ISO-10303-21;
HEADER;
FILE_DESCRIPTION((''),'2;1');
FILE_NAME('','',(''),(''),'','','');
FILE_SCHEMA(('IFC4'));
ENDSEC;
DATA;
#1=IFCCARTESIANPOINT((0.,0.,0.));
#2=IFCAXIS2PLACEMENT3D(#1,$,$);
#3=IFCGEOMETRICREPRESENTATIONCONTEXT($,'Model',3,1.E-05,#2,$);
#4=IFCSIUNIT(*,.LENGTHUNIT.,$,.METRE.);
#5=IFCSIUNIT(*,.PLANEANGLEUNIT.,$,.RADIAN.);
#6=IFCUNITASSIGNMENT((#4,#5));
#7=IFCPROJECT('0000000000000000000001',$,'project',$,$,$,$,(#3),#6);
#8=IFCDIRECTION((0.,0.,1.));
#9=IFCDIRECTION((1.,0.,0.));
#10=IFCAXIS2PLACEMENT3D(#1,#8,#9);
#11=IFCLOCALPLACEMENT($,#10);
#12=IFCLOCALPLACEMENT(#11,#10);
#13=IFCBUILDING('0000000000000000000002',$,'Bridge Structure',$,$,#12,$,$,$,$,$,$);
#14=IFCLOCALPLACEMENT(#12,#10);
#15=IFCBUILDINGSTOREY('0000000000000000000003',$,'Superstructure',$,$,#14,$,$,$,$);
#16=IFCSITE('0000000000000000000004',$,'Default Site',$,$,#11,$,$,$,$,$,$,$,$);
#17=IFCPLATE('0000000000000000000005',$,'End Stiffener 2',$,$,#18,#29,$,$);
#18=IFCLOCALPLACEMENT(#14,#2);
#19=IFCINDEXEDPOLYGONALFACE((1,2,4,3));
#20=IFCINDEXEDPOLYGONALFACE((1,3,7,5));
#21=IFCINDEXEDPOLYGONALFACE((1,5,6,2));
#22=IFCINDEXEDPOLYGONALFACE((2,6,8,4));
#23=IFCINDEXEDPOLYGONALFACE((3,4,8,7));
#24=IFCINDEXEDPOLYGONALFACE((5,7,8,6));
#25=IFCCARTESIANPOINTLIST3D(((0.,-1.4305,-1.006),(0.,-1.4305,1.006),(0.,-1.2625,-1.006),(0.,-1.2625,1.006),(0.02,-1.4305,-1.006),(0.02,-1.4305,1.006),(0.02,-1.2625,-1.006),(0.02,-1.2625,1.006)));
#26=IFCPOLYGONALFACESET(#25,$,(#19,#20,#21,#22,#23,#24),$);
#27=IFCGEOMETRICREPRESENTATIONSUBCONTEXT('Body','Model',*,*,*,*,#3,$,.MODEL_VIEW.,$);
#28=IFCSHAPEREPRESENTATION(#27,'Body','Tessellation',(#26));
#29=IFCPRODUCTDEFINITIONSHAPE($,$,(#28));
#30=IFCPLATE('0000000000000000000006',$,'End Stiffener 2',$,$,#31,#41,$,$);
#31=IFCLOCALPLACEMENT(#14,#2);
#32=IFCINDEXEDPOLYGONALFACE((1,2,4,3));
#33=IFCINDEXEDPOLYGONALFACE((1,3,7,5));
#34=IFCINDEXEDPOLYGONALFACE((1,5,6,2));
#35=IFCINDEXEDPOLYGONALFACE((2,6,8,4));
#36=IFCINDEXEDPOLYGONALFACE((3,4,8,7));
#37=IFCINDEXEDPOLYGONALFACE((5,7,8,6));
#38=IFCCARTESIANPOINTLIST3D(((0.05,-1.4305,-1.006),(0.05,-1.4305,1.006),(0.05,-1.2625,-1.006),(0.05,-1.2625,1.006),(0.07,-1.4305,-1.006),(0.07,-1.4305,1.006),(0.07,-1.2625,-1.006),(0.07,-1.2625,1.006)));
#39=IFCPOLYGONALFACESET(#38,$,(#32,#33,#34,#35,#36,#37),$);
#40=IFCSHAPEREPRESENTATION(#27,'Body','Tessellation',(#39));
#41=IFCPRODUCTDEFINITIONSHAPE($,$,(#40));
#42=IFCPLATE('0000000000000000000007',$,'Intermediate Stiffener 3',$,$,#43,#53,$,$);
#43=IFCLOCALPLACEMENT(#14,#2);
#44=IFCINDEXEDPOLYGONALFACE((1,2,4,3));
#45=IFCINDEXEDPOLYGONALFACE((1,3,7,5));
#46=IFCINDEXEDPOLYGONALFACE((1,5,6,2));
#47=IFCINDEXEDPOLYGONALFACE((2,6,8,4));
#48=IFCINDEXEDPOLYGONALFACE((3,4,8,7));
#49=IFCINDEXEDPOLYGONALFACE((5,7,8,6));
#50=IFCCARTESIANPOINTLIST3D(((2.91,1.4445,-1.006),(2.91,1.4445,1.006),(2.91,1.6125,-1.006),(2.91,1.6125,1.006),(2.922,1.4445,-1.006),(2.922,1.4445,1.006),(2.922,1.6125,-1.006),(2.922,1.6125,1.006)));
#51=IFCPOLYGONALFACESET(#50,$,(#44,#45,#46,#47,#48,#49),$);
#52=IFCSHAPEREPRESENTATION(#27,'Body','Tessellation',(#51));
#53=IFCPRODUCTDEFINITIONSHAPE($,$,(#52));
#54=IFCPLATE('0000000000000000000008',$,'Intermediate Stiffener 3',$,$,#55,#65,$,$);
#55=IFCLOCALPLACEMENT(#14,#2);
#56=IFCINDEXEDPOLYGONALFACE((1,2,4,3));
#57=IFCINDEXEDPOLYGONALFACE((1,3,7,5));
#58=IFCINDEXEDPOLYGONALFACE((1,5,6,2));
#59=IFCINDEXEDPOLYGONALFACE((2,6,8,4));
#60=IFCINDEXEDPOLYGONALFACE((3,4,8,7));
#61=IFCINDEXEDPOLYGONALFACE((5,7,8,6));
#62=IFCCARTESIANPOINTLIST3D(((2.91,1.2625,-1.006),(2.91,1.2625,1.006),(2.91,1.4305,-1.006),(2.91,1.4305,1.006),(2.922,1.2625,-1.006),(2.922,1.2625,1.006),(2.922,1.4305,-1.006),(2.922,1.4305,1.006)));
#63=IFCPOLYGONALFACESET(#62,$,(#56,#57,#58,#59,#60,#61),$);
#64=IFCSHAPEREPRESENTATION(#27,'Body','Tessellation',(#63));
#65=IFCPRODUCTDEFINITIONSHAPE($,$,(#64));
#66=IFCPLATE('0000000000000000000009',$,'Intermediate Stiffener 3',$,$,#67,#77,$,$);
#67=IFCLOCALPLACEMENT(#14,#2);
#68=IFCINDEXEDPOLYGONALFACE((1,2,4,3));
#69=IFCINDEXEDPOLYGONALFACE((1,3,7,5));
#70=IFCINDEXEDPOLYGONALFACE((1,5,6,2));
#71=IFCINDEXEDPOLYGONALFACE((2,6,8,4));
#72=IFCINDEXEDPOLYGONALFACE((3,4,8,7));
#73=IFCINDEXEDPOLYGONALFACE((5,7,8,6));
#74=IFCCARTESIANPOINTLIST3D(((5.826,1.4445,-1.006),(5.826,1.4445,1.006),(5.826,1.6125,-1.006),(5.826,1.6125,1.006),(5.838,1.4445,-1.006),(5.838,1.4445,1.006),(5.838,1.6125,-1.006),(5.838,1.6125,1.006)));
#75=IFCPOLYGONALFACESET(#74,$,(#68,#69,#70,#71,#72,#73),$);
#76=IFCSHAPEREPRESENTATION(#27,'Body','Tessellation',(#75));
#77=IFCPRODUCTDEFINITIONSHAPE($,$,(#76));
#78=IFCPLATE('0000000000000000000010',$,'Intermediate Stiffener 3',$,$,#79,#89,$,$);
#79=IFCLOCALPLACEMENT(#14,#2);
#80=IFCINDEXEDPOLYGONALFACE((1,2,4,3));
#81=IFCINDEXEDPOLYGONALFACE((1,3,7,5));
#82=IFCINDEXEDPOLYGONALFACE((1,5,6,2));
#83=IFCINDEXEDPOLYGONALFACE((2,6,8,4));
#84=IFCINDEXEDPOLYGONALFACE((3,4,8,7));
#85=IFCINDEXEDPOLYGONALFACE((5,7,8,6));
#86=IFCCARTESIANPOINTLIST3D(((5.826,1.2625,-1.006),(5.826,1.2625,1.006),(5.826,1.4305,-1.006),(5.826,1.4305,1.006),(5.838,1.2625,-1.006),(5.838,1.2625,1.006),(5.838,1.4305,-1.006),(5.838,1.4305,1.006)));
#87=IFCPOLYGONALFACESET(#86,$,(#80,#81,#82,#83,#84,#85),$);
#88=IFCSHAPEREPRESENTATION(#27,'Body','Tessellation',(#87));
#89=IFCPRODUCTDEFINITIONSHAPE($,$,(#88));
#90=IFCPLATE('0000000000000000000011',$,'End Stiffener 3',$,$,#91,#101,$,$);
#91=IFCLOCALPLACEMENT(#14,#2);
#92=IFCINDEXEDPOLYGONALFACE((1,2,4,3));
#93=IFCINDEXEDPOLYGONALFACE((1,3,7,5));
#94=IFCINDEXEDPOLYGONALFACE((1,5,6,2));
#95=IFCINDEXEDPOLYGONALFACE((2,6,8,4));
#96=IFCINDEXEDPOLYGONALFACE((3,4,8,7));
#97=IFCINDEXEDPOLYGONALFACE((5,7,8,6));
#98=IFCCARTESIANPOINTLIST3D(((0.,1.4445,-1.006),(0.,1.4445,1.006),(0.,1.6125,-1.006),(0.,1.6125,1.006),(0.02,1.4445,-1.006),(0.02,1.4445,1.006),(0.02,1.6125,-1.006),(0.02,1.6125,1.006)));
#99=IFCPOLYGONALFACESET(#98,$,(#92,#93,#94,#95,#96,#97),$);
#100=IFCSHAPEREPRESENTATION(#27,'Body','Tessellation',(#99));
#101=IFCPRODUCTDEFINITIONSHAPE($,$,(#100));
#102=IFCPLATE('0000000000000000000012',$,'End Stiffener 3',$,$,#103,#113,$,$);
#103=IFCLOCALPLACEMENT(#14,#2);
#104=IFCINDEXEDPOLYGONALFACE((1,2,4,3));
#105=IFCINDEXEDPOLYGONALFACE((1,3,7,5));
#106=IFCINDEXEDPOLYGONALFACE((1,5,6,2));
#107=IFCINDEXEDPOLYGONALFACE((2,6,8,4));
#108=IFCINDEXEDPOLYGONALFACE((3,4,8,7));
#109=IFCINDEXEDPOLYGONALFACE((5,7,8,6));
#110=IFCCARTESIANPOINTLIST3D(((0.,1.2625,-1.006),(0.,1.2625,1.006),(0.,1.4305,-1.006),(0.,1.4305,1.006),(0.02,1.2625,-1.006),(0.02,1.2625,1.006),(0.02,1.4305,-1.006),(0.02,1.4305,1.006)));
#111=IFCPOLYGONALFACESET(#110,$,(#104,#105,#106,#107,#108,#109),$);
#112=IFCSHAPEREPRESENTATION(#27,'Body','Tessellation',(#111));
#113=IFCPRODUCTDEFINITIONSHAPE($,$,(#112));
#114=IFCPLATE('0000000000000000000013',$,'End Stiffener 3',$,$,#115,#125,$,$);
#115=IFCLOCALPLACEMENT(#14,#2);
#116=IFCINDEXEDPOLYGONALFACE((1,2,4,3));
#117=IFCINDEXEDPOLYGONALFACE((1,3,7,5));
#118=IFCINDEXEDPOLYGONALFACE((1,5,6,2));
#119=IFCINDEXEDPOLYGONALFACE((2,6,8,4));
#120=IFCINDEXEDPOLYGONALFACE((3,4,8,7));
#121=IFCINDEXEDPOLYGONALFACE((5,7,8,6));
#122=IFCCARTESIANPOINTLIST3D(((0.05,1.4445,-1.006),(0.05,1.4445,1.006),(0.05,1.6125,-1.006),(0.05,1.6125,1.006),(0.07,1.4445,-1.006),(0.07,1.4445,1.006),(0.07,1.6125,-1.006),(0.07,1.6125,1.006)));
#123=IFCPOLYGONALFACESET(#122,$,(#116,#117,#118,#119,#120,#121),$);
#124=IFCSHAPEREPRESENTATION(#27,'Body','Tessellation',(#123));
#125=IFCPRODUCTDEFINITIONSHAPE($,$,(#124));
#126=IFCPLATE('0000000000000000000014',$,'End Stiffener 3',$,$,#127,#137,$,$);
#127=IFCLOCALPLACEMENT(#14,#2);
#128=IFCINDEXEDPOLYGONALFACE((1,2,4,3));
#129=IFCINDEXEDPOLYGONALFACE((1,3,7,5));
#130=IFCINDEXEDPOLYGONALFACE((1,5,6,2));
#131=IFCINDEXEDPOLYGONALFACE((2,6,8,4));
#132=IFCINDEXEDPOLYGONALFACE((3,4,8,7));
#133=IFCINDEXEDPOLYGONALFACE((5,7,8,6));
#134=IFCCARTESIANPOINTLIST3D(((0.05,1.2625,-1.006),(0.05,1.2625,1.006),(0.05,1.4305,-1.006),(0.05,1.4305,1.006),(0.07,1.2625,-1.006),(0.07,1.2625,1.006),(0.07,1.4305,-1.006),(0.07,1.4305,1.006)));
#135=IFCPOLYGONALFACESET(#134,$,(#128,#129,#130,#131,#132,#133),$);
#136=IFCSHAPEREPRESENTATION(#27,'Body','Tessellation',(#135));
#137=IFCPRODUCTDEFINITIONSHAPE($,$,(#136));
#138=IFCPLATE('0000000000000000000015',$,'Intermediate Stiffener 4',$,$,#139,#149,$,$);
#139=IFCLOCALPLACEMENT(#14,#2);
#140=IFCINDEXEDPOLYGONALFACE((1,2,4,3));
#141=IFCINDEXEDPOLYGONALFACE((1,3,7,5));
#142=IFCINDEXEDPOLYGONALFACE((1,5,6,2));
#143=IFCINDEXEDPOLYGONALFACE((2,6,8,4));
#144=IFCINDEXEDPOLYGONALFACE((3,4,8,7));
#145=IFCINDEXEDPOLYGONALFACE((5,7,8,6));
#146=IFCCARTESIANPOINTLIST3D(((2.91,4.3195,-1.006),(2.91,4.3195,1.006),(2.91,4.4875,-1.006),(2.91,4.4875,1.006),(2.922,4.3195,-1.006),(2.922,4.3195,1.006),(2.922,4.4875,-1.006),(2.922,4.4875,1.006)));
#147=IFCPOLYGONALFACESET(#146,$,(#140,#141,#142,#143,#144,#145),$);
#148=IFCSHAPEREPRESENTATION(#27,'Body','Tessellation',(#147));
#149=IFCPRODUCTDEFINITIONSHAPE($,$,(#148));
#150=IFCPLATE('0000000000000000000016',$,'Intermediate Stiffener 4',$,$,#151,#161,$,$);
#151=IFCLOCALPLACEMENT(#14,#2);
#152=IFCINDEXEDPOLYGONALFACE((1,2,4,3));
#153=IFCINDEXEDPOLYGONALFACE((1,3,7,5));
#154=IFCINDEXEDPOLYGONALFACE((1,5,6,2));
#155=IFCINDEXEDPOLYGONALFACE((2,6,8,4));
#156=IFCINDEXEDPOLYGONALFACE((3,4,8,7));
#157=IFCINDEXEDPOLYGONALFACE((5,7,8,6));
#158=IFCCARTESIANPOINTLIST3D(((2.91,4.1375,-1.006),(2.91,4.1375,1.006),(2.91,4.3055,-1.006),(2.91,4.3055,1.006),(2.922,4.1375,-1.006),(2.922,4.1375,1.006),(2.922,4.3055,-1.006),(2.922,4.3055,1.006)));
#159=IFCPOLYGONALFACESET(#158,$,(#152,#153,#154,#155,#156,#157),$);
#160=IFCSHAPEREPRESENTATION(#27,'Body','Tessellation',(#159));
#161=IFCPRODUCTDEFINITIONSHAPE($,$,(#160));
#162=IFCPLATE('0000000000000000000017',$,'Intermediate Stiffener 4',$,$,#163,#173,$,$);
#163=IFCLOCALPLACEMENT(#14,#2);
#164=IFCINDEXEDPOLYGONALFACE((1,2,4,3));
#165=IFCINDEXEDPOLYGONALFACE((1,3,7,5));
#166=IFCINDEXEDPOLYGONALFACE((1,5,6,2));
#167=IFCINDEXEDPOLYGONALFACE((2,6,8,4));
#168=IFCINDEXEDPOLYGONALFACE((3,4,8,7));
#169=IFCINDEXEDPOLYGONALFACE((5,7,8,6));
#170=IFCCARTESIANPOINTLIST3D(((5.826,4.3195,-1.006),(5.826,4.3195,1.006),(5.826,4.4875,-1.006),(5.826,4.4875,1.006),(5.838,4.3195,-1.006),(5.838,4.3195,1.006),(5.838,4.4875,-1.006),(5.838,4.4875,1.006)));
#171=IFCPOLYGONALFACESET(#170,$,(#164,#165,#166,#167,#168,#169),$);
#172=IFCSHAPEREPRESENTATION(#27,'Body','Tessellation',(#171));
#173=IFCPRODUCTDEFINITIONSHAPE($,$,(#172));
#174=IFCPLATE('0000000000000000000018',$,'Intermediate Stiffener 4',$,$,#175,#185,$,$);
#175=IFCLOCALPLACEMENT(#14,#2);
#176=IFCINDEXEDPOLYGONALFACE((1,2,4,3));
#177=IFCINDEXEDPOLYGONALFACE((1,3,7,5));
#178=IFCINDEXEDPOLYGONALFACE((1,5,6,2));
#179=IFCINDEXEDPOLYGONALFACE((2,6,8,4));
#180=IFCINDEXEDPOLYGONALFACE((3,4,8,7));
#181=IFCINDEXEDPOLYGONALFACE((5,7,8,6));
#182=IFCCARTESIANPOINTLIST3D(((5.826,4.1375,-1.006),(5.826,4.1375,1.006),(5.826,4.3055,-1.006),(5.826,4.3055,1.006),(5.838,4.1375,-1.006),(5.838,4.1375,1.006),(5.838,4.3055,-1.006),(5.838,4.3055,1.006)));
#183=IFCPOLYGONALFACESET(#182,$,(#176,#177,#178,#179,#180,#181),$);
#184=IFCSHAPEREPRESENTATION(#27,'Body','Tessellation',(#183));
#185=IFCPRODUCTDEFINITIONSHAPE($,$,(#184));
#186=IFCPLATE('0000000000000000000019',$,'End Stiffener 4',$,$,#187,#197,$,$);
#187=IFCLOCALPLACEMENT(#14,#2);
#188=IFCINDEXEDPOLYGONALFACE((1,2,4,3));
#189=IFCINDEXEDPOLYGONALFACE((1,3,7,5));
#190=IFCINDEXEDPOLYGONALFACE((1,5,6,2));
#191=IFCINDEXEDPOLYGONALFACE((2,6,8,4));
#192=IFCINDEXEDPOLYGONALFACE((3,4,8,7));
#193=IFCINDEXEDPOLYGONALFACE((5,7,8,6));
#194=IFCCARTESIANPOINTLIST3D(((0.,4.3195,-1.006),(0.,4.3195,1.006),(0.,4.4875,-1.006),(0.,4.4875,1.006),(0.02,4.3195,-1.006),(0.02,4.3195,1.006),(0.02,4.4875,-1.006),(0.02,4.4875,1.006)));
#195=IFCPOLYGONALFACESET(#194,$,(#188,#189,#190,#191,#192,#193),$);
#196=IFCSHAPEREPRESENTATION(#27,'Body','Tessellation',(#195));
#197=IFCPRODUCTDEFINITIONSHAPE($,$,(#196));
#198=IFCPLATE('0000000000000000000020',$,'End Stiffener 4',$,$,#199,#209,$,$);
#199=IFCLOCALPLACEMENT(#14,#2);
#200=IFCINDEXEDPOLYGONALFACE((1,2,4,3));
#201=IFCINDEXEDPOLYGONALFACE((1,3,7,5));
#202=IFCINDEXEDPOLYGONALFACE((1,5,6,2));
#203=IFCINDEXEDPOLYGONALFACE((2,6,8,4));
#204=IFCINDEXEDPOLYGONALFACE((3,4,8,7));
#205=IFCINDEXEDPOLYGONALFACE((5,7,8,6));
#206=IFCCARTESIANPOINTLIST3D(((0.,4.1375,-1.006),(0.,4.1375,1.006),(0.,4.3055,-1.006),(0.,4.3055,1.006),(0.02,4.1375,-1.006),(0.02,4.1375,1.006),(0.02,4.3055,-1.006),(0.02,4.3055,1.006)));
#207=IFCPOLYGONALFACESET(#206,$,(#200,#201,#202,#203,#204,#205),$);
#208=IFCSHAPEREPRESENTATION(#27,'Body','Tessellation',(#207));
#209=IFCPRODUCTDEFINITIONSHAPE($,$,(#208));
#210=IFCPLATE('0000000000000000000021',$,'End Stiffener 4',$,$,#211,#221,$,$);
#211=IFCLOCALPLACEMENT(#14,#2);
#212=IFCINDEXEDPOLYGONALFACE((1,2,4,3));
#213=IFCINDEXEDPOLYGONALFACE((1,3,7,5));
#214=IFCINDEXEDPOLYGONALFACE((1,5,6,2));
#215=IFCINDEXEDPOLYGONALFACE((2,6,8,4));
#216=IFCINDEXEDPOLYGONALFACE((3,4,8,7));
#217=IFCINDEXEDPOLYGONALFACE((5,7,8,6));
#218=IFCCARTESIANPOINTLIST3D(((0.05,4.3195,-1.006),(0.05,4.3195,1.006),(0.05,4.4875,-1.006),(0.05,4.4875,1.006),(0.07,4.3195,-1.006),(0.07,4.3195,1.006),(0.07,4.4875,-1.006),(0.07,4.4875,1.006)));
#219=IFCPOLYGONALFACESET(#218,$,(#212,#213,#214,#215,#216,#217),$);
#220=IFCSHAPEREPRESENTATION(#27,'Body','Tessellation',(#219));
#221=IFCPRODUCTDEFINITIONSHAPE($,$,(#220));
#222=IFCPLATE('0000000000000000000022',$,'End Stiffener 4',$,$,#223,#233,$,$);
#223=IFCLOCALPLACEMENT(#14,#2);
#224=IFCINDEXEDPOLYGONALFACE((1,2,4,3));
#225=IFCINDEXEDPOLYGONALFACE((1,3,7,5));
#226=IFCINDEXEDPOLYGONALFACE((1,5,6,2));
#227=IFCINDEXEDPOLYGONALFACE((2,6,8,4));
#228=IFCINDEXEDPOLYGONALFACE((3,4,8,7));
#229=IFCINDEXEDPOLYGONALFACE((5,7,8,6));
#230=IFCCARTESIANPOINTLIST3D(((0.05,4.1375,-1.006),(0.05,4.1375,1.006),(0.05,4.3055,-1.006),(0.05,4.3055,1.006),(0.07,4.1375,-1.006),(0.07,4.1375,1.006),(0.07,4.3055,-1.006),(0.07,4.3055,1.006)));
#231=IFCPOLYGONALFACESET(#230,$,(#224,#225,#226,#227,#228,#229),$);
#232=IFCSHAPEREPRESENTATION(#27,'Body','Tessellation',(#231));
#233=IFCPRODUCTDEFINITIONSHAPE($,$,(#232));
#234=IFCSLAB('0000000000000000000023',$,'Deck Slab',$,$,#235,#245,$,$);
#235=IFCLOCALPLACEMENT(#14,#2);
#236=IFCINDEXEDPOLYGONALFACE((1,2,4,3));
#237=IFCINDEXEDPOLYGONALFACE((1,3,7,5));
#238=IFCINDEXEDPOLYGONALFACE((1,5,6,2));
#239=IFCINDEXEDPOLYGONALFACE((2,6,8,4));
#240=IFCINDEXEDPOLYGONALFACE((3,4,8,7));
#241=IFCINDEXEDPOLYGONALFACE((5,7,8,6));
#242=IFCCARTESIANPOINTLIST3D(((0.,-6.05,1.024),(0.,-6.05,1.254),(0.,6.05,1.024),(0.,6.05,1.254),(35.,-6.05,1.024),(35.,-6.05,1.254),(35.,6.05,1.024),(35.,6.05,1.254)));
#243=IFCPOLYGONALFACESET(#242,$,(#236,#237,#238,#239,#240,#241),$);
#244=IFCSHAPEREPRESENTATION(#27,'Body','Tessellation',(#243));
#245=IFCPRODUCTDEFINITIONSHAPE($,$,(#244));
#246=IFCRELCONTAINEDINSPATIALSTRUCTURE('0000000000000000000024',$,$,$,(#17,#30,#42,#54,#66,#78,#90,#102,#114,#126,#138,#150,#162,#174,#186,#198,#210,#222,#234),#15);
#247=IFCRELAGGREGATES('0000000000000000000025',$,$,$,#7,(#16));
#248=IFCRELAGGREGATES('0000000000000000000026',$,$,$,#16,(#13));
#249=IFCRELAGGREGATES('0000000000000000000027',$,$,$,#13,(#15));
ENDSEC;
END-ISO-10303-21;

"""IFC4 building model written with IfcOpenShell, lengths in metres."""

from ifc_helpers import new_model, si_unit, frame, origin, origin_with_axes, origin_2d_with_axis, place, context, subcontext, project, spatial, polyline, rectangle, outline, extrude, element, save


model = new_model("IFC4")

# Units and contexts
model_context = context("Model", 3, precision=1e-05, world=origin())
body_context = subcontext(model_context, "Body", "Model", "MODEL_VIEW")
ifc_project = project(units=[si_unit("LENGTHUNIT", "METRE"), si_unit("PLANEANGLEUNIT", "RADIAN")], contexts=[model_context])

# Site, building, storey
site_placement = place(None, origin_with_axes())
site = spatial("IfcSite", under=ifc_project, at=site_placement, Name="Default Site")
building_placement = place(site_placement, origin_with_axes())
building = spatial("IfcBuilding", under=site, at=building_placement, Name="Bridge Structure")
storey_placement = place(building_placement, origin_with_axes())
storey = spatial("IfcBuildingStorey", under=building, at=storey_placement, Name="Superstructure")

# Plates
for number, where, z_axis, x_axis, name in (
    (1, (0.01, -1.3465, -1.006), (0.0, 0.0, 1.0), (1.0, 0.0, 0.0), "End Stiffener 2"),
    (2, (0.06, -1.3465, -1.006), (0.0, 0.0, 1.0), (1.0, 0.0, 0.0), "End Stiffener 2"),
):
    element("IfcPlate", number, at=place(storey_placement, frame(where, z_axis=z_axis, x_axis=x_axis)), inside=storey, Name=name, context=body_context, shape_type="SweptSolid", body=[
        extrude(rectangle(XDim=0.02, YDim=0.168, at=origin_2d_with_axis()), origin_with_axes(), (0.0, 0.0, 1.0), 2.012),
    ])
for number, where, z_axis, x_axis, name in (
    (3, (2.916, 1.5285, -1.006), (0.0, 0.0, 1.0), (1.0, 0.0, 0.0), "Intermediate Stiffener 3"),
    (4, (2.916, 1.3465, -1.006), (0.0, 0.0, 1.0), (1.0, 0.0, 0.0), "Intermediate Stiffener 3"),
    (5, (5.832, 1.5285, -1.006), (0.0, 0.0, 1.0), (1.0, 0.0, 0.0), "Intermediate Stiffener 3"),
    (6, (5.832, 1.3465, -1.006), (0.0, 0.0, 1.0), (1.0, 0.0, 0.0), "Intermediate Stiffener 3"),
):
    element("IfcPlate", number, at=place(storey_placement, frame(where, z_axis=z_axis, x_axis=x_axis)), inside=storey, Name=name, context=body_context, shape_type="SweptSolid", body=[
        extrude(rectangle(XDim=0.012, YDim=0.168, at=origin_2d_with_axis()), origin_with_axes(), (0.0, 0.0, 1.0), 2.012),
    ])
for number, where, z_axis, x_axis, name in (
    (7, (0.01, 1.5285, -1.006), (0.0, 0.0, 1.0), (1.0, 0.0, 0.0), "End Stiffener 3"),
    (8, (0.01, 1.3465, -1.006), (0.0, 0.0, 1.0), (1.0, 0.0, 0.0), "End Stiffener 3"),
    (9, (0.06, 1.5285, -1.006), (0.0, 0.0, 1.0), (1.0, 0.0, 0.0), "End Stiffener 3"),
    (10, (0.06, 1.3465, -1.006), (0.0, 0.0, 1.0), (1.0, 0.0, 0.0), "End Stiffener 3"),
):
    element("IfcPlate", number, at=place(storey_placement, frame(where, z_axis=z_axis, x_axis=x_axis)), inside=storey, Name=name, context=body_context, shape_type="SweptSolid", body=[
        extrude(rectangle(XDim=0.02, YDim=0.168, at=origin_2d_with_axis()), origin_with_axes(), (0.0, 0.0, 1.0), 2.012),
    ])
for number, where, z_axis, x_axis, name in (
    (11, (2.916, 4.4035, -1.006), (0.0, 0.0, 1.0), (1.0, 0.0, 0.0), "Intermediate Stiffener 4"),
    (12, (2.916, 4.2215, -1.006), (0.0, 0.0, 1.0), (1.0, 0.0, 0.0), "Intermediate Stiffener 4"),
    (13, (5.832, 4.4035, -1.006), (0.0, 0.0, 1.0), (1.0, 0.0, 0.0), "Intermediate Stiffener 4"),
    (14, (5.832, 4.2215, -1.006), (0.0, 0.0, 1.0), (1.0, 0.0, 0.0), "Intermediate Stiffener 4"),
):
    element("IfcPlate", number, at=place(storey_placement, frame(where, z_axis=z_axis, x_axis=x_axis)), inside=storey, Name=name, context=body_context, shape_type="SweptSolid", body=[
        extrude(rectangle(XDim=0.012, YDim=0.168, at=origin_2d_with_axis()), origin_with_axes(), (0.0, 0.0, 1.0), 2.012),
    ])
for number, where, z_axis, x_axis, name in (
    (15, (0.01, 4.4035, -1.006), (0.0, 0.0, 1.0), (1.0, 0.0, 0.0), "End Stiffener 4"),
    (16, (0.01, 4.2215, -1.006), (0.0, 0.0, 1.0), (1.0, 0.0, 0.0), "End Stiffener 4"),
    (17, (0.06, 4.4035, -1.006), (0.0, 0.0, 1.0), (1.0, 0.0, 0.0), "End Stiffener 4"),
    (18, (0.06, 4.2215, -1.006), (0.0, 0.0, 1.0), (1.0, 0.0, 0.0), "End Stiffener 4"),
):
    element("IfcPlate", number, at=place(storey_placement, frame(where, z_axis=z_axis, x_axis=x_axis)), inside=storey, Name=name, context=body_context, shape_type="SweptSolid", body=[
        extrude(rectangle(XDim=0.02, YDim=0.168, at=origin_2d_with_axis()), origin_with_axes(), (0.0, 0.0, 1.0), 2.012),
    ])

# Slab
slab_placement = place(storey_placement, frame((0.0, 0.0, 1.024), z_axis=(0.0, 0.0, 1.0), x_axis=(1.0, 0.0, 0.0)))
element("IfcSlab", 19, at=slab_placement, inside=storey, Name="Deck Slab", context=body_context, shape_type="SweptSolid", body=[
    extrude(outline(polyline([(0.0, -6.05), (35.0, -6.05), (35.0, 6.05), (0.0, 6.05), (0.0, -6.05)])), origin_with_axes(), (0.0, 0.0, 1.0), 0.23),
])

save(model, "model.ifc")
